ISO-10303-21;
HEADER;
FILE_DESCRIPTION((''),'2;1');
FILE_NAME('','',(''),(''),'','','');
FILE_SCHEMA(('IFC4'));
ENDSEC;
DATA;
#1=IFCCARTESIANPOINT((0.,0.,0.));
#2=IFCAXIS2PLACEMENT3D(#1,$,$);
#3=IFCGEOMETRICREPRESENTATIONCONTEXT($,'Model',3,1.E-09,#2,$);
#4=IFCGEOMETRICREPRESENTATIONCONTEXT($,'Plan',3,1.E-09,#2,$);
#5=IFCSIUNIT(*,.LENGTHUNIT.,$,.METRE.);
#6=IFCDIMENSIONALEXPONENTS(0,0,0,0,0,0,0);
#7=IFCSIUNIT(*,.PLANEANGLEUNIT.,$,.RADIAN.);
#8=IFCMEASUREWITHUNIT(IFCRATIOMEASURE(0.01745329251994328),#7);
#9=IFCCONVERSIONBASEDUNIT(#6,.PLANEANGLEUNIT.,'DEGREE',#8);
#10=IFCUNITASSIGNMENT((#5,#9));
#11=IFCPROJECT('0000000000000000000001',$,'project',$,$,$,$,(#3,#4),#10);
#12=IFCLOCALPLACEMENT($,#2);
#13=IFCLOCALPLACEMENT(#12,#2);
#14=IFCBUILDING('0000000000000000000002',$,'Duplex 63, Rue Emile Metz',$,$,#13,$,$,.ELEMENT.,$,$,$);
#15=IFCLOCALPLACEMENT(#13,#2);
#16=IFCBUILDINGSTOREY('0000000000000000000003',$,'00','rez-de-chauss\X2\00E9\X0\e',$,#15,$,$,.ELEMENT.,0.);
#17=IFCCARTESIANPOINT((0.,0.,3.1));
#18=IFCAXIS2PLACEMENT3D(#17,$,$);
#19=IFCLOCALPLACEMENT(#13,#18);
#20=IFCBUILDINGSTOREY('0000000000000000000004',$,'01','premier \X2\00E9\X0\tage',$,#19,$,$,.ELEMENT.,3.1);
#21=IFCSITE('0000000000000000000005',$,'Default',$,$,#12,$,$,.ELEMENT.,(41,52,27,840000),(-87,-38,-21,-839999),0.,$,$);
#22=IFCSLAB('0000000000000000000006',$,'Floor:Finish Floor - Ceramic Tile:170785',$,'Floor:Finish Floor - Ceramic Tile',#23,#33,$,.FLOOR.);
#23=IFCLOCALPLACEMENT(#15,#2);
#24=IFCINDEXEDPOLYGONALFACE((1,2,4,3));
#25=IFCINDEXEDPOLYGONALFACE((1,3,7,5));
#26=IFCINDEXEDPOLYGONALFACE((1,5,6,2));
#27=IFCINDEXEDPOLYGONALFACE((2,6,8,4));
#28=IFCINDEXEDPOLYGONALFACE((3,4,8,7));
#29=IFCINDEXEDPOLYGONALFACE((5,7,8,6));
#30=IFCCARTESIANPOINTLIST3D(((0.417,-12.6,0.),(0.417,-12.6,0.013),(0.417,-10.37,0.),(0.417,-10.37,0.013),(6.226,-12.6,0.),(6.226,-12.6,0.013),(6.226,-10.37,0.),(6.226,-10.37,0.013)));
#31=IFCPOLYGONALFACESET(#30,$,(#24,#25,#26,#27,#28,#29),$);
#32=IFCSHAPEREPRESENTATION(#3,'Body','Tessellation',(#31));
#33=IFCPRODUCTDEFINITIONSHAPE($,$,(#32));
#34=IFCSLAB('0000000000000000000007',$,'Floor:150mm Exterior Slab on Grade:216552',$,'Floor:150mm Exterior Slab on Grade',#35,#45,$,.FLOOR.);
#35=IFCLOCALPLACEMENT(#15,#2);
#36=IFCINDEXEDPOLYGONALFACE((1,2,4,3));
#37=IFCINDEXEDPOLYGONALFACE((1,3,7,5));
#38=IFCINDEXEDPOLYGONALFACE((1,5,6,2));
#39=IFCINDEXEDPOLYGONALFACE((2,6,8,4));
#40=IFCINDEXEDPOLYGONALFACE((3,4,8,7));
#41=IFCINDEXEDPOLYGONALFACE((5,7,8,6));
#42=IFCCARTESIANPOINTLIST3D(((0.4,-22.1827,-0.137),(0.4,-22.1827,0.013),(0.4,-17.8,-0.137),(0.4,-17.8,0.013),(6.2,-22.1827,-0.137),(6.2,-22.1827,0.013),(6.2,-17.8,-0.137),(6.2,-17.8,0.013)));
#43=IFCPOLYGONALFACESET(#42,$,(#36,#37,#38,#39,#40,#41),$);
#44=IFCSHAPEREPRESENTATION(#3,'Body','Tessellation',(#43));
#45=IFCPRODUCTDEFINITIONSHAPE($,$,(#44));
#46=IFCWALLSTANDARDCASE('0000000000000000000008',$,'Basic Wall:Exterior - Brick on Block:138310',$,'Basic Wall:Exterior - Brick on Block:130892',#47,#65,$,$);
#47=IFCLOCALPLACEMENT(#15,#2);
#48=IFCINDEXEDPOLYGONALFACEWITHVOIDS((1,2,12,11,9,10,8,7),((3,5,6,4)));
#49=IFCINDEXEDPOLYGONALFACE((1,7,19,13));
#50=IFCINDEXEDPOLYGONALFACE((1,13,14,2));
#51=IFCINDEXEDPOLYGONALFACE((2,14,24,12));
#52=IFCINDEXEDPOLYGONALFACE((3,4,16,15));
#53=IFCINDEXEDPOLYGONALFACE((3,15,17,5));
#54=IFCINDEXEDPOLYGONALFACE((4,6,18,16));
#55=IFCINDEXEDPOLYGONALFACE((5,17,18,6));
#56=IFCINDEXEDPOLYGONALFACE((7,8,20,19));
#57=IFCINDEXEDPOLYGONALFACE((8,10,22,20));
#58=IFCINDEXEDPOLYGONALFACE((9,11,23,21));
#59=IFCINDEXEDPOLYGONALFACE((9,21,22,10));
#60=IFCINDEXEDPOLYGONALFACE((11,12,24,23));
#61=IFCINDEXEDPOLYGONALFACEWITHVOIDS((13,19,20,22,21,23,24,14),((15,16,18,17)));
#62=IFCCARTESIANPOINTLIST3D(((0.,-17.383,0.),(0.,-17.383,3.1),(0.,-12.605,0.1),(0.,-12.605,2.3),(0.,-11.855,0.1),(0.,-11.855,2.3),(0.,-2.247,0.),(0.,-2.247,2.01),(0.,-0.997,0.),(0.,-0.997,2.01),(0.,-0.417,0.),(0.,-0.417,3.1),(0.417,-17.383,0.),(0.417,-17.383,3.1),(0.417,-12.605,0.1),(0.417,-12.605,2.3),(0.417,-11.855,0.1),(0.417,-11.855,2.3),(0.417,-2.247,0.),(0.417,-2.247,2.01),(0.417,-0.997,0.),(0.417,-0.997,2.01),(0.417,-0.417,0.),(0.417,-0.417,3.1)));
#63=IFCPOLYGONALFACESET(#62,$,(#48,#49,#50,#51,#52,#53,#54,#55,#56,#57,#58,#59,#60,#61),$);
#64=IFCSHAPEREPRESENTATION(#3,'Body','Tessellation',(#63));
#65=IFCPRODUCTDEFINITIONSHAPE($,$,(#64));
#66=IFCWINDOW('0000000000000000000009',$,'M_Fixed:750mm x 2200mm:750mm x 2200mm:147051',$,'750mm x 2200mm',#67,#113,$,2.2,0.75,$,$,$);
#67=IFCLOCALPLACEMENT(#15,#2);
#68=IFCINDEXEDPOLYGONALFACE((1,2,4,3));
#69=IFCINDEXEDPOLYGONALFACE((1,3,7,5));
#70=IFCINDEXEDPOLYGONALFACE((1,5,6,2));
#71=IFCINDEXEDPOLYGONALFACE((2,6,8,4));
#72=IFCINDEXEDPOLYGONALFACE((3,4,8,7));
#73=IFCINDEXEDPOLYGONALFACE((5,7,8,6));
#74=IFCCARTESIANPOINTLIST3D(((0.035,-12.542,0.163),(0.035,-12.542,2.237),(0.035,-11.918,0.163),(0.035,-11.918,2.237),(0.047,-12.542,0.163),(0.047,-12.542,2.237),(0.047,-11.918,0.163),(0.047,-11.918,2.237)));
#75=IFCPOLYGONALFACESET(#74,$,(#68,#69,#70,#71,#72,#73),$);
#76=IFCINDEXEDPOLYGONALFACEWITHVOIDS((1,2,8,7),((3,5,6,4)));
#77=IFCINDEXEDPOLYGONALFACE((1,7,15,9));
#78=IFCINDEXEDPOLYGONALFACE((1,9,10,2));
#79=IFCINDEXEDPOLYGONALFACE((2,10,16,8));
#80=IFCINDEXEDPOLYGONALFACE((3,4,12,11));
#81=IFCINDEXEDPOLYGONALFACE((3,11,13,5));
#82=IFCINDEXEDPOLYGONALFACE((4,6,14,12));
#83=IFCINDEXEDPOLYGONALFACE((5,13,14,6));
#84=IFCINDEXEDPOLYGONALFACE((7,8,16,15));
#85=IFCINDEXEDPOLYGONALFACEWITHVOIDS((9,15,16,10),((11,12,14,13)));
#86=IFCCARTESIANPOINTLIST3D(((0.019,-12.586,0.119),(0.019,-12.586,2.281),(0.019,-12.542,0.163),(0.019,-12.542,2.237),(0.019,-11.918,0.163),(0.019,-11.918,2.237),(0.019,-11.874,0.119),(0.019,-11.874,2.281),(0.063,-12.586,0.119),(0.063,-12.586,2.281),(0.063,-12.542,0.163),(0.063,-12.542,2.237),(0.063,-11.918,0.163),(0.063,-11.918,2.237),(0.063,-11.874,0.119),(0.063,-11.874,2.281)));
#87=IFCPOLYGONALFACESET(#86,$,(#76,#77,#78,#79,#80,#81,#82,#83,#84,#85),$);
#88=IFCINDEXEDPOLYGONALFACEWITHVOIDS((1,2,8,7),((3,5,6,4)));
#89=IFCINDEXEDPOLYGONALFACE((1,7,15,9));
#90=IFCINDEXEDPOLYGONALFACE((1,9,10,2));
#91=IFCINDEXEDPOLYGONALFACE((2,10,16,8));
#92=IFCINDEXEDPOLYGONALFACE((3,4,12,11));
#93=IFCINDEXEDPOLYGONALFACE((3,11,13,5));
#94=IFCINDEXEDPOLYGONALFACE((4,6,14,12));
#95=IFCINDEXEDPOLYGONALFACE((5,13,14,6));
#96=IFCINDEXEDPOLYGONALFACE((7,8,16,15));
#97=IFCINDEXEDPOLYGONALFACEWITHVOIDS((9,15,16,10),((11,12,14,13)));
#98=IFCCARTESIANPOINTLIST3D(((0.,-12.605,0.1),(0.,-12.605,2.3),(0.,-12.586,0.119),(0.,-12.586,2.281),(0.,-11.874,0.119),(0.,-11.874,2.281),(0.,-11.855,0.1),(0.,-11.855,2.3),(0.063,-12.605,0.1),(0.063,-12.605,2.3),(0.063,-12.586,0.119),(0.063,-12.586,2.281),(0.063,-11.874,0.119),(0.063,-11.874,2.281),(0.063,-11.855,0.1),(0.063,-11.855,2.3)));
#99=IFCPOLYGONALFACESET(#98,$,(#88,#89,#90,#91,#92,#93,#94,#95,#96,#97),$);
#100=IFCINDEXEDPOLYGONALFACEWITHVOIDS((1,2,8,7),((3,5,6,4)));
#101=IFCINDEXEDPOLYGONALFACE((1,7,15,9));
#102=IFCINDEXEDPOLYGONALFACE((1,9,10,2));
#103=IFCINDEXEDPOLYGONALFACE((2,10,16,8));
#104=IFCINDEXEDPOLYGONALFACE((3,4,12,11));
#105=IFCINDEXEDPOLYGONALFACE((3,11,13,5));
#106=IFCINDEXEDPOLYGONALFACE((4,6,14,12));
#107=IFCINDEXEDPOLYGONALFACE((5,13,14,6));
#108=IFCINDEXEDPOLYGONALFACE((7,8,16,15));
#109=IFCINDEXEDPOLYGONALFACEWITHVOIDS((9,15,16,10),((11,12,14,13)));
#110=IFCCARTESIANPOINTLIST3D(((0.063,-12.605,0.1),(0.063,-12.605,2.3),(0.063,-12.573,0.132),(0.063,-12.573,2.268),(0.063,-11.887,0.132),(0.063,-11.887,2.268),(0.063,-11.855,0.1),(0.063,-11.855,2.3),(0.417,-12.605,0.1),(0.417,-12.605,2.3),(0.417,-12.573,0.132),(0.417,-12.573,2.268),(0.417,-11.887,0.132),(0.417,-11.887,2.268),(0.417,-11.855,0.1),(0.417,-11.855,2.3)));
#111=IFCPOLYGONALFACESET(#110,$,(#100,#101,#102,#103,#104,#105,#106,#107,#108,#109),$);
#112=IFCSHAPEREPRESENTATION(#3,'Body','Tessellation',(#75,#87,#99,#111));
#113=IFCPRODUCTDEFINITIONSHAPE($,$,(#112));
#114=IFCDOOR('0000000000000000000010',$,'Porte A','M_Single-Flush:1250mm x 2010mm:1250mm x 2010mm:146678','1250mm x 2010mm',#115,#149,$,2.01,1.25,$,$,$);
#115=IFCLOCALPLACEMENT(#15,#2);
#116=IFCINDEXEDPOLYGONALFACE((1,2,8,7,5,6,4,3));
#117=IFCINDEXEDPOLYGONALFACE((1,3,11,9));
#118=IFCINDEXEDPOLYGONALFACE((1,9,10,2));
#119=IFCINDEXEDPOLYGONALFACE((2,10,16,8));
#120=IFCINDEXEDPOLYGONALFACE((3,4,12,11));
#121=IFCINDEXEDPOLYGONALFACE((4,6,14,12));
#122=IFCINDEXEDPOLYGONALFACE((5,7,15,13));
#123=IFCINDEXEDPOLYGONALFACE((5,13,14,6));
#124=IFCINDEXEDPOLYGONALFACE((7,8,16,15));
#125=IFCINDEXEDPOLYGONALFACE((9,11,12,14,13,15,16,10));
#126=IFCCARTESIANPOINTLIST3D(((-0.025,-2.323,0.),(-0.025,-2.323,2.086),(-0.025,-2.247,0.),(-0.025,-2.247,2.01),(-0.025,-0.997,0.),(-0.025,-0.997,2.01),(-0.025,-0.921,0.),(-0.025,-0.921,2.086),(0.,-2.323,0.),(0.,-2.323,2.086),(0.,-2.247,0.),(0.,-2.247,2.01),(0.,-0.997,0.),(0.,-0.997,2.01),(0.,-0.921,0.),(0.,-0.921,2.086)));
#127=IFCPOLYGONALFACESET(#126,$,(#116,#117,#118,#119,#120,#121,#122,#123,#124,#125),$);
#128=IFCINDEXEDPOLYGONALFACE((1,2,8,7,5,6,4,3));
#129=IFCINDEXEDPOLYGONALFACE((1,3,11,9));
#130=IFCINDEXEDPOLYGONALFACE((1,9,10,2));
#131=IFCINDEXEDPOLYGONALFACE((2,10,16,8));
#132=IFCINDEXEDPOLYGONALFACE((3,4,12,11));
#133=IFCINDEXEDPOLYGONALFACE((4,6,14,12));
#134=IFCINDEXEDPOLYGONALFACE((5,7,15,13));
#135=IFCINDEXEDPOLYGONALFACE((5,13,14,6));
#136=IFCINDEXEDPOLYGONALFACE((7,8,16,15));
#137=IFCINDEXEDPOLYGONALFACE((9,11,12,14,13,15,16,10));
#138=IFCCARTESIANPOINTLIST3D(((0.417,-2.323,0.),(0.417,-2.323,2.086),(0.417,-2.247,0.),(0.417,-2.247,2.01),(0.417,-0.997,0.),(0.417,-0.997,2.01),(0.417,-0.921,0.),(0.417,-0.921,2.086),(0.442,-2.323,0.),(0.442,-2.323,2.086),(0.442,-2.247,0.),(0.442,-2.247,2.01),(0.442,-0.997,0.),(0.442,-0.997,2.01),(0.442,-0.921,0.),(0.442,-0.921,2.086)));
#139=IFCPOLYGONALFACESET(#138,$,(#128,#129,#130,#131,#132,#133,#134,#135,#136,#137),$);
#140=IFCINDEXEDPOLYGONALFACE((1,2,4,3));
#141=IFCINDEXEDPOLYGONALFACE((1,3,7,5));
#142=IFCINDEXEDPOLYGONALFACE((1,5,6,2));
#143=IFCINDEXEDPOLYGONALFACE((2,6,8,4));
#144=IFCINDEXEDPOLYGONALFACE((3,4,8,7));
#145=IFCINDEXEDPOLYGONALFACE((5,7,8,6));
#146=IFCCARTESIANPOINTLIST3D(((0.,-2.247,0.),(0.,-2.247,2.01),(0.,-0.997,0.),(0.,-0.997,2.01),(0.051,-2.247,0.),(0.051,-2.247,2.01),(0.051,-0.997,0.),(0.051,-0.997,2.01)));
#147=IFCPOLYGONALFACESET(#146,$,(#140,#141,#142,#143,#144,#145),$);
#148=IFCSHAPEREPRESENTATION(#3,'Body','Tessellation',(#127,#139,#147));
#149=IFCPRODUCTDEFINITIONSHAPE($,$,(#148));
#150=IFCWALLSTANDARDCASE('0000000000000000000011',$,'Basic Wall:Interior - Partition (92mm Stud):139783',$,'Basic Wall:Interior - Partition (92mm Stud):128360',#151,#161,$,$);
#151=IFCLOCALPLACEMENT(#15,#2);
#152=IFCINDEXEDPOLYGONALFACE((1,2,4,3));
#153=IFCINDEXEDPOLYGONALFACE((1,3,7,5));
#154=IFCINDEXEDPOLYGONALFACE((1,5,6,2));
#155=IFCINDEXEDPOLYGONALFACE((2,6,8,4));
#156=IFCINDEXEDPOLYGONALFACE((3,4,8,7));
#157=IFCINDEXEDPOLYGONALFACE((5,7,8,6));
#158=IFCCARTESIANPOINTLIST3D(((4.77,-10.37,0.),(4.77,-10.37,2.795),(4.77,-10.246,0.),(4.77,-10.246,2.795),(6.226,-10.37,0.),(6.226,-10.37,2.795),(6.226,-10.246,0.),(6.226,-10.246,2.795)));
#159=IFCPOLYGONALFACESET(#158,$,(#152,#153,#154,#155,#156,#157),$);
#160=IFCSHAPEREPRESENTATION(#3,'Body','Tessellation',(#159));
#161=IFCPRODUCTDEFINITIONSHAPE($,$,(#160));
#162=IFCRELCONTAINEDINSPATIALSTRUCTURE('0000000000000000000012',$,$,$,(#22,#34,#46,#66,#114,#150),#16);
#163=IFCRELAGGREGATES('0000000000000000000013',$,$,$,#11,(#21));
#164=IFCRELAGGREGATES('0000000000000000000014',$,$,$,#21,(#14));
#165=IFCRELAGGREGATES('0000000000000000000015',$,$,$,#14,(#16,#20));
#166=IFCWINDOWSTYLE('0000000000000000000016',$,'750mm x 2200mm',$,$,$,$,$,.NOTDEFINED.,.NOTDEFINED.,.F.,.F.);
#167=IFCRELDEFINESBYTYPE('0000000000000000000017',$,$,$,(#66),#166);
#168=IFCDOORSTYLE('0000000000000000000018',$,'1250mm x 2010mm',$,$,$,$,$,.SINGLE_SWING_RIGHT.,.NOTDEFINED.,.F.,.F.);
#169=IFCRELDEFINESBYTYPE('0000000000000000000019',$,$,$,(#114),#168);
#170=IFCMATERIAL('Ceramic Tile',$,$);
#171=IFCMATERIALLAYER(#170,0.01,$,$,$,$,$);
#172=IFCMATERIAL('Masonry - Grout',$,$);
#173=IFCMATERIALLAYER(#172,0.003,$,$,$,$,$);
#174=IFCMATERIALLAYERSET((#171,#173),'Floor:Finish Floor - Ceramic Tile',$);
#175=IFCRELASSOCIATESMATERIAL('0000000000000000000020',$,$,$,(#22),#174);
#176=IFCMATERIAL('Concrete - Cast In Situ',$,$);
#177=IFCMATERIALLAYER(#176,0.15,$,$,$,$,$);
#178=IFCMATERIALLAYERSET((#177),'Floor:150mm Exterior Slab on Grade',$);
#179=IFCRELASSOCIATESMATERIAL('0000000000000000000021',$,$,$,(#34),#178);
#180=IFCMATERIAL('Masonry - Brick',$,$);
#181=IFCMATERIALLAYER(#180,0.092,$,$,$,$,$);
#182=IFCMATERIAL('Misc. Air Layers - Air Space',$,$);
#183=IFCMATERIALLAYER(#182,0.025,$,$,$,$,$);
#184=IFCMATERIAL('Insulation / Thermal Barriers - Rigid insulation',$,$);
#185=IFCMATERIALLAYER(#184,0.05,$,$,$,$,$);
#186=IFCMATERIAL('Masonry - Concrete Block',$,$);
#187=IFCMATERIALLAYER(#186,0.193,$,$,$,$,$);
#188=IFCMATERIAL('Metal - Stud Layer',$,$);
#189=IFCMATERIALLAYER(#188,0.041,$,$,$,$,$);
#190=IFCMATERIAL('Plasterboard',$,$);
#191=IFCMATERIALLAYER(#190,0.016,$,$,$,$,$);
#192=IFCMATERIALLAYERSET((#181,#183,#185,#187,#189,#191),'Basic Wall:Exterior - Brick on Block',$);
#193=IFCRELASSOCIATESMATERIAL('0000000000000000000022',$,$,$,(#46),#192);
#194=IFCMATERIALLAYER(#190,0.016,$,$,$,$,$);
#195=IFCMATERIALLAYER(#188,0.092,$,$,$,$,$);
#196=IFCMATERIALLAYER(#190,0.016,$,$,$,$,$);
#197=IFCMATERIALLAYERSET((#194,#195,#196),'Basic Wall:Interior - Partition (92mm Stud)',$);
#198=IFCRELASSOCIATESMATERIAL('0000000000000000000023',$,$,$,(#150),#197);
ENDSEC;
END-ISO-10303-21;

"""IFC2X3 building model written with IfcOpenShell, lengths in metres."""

from ifc_helpers import new_model, entity, si_unit, converted_unit, frame, frame_2d, origin, origin_2d_with_axis, place, context, project, spatial, polyline, rectangle, outline, extrude, source, transform, mapped, material, layer, layer_set, layer_usage, type_object, type_shapes, element, fill, save


model = new_model("IFC2X3")

# Units and contexts
model_context = context("Model", 3, precision=1e-09, world=origin())
plan_context = context("Plan", 3, precision=1e-09, world=origin())
ifc_project = project(units=[si_unit("LENGTHUNIT", "METRE"), converted_unit("PLANEANGLEUNIT", "DEGREE", entity("IfcRatioMeasure", 0.01745329251994328), si_unit("PLANEANGLEUNIT", "RADIAN"), dimensions=[0, 0, 0, 0, 0, 0, 0])], contexts=[model_context, plan_context])

# Site, building, storey
site_placement = place(None, origin())
site = spatial("IfcSite", under=ifc_project, at=site_placement, Name="Default", CompositionType="ELEMENT", RefLatitude=(41, 52, 27, 840000), RefLongitude=(-87, -38, -21, -839999), RefElevation=0.0)
building_placement = place(site_placement, origin())
building = spatial("IfcBuilding", under=site, at=building_placement, Name="Duplex 63, Rue Emile Metz", CompositionType="ELEMENT")
storey_1_placement = place(building_placement, origin())
storey_1 = spatial("IfcBuildingStorey", under=building, at=storey_1_placement, Name="00", Description="rez-de-chaussée", CompositionType="ELEMENT", Elevation=0.0)

# Slabs
ifc_material_1 = material(Name="Ceramic Tile")
ifc_layer_1 = layer(ifc_material_1, 0.01)
ifc_material_2 = material(Name="Masonry - Grout")
ifc_layer_2 = layer(ifc_material_2, 0.003)
ifc_layer_set_1 = layer_set([ifc_layer_1, ifc_layer_2], Name="Floor:Finish Floor - Ceramic Tile")
ifc_layer_usage_1 = layer_usage(ifc_layer_set_1, "AXIS3", "POSITIVE", 0.0)
slab_1_placement = place(storey_1_placement, frame((0.417, -12.6, 0.0)))
element("IfcSlab", 1, at=slab_1_placement, inside=storey_1, material=ifc_layer_usage_1, Name="Floor:Finish Floor - Ceramic Tile:170785", ObjectType="Floor:Finish Floor - Ceramic Tile", PredefinedType="FLOOR", context=model_context, shape_type="SweptSolid", body=[
    extrude(rectangle(XDim=5.809, YDim=2.23, at=frame_2d((0.0, 0.0), x_axis=(-1.0, 0.0))), frame((2.9045, 1.115, 0.013), z_axis=(0.0, 0.0, -1.0), x_axis=(-1.0, 0.0, 0.0)), (0.0, 0.0, 1.0), 0.013),
])
ifc_material_3 = material(Name="Concrete - Cast In Situ")
ifc_layer_3 = layer(ifc_material_3, 0.15)
ifc_layer_set_2 = layer_set([ifc_layer_3], Name="Floor:150mm Exterior Slab on Grade")
ifc_layer_usage_2 = layer_usage(ifc_layer_set_2, "AXIS3", "POSITIVE", 0.0)
slab_2_placement = place(storey_1_placement, frame((0.4, -22.1827, -0.137)))
element("IfcSlab", 2, at=slab_2_placement, inside=storey_1, material=ifc_layer_usage_2, Name="Floor:150mm Exterior Slab on Grade:216552", ObjectType="Floor:150mm Exterior Slab on Grade", PredefinedType="FLOOR", context=model_context, shape_type="SweptSolid", body=[
    extrude(rectangle(XDim=5.8, YDim=4.3827, at=origin_2d_with_axis()), frame((2.9, 2.1914, 0.15), z_axis=(0.0, 0.0, -1.0), x_axis=(-1.0, 0.0, 0.0)), (0.0, 0.0, 1.0), 0.15),
])

# Wall, openings, window, door
ifc_material_4 = material(Name="Masonry - Brick")
ifc_layer_4 = layer(ifc_material_4, 0.092)
ifc_material_5 = material(Name="Misc. Air Layers - Air Space")
ifc_layer_5 = layer(ifc_material_5, 0.025)
ifc_material_6 = material(Name="Insulation / Thermal Barriers - Rigid insulation")
ifc_layer_6 = layer(ifc_material_6, 0.05)
ifc_material_7 = material(Name="Masonry - Concrete Block")
ifc_layer_7 = layer(ifc_material_7, 0.193)
ifc_material_8 = material(Name="Metal - Stud Layer")
ifc_layer_8 = layer(ifc_material_8, 0.041)
ifc_material_9 = material(Name="Plasterboard")
ifc_layer_9 = layer(ifc_material_9, 0.016)
ifc_layer_set_3 = layer_set([ifc_layer_4, ifc_layer_5, ifc_layer_6, ifc_layer_7, ifc_layer_8, ifc_layer_9], Name="Basic Wall:Exterior - Brick on Block")
ifc_layer_usage_3 = layer_usage(ifc_layer_set_3, "AXIS2", "NEGATIVE", 0.2085)
wall_1_placement = place(storey_1_placement, frame((0.2085, -17.383, 0.0), z_axis=(0.0, 0.0, 1.0), x_axis=(0.0, 1.0, 0.0)))
wall_1 = element("IfcWallStandardCase", 3, at=wall_1_placement, inside=storey_1, material=ifc_layer_usage_3, Name="Basic Wall:Exterior - Brick on Block:138310", ObjectType="Basic Wall:Exterior - Brick on Block:130892", context=model_context, shape_type="SweptSolid", body=[
    extrude(rectangle(XDim=16.966, YDim=0.417, at=frame_2d((8.483, 0.0), x_axis=(-1.0, 0.0))), origin(), (0.0, 0.0, 1.0), 3.1),
])
opening_1_placement = place(wall_1_placement, frame((15.136, -0.2085, 0.0)))
opening_1 = element("IfcOpeningElement", 4, at=opening_1_placement, cuts=wall_1, ObjectType="Opening", context=model_context, shape_type="SweptSolid", body=[
    extrude(rectangle(XDim=1.25, YDim=2.01, at=frame_2d((1.005, 0.625), x_axis=(0.0, 1.0))), frame((0.0, 0.0, 0.0), z_axis=(0.0, 1.0, 0.0), x_axis=(0.0, 0.0, 1.0)), (0.0, 0.0, 1.0), 0.417),
])
opening_2_placement = place(wall_1_placement, frame((4.778, -0.2085, 0.1)))
opening_2 = element("IfcOpeningElement", 5, at=opening_2_placement, cuts=wall_1, ObjectType="Opening", context=model_context, shape_type="SweptSolid", body=[
    extrude(rectangle(XDim=2.2, YDim=0.75, at=frame_2d((1.1, 0.375), x_axis=(1.0, 0.0))), frame((0.0, 0.0, 0.0), z_axis=(0.0, 1.0, 0.0), x_axis=(0.0, 0.0, 1.0)), (0.0, 0.0, 1.0), 0.417),
])
window_style_1 = type_object("IfcWindowStyle", Name="750mm x 2200mm", ConstructionType="NOTDEFINED", OperationType="NOTDEFINED", ParameterTakesPrecedence=False, Sizeable=False)
shared_shape_1 = source(origin(), model_context, "Body", "SweptSolid", [
    extrude(rectangle(XDim=0.012, YDim=0.624, at=origin_2d_with_axis()), frame((0.375, 0.376, 0.063), z_axis=(0.0, 0.0, 1.0), x_axis=(0.0, -1.0, 0.0)), (0.0, 0.0, 1.0), 2.074),
    extrude(outline(polyline([(-0.356, -1.081), (0.356, -1.081), (0.356, 1.081), (-0.356, 1.081), (-0.356, -1.081)]), holes=[polyline([(-0.312, -1.037), (-0.312, 1.037), (0.312, 1.037), (0.312, -1.037), (-0.312, -1.037)])]), frame((0.375, 0.354, 1.1), z_axis=(0.0, 1.0, 0.0), x_axis=(1.0, 0.0, 0.0)), (0.0, 0.0, 1.0), 0.044),
    extrude(outline(polyline([(-0.375, -1.1), (0.375, -1.1), (0.375, 1.1), (-0.375, 1.1), (-0.375, -1.1)]), holes=[polyline([(-0.356, -1.081), (-0.356, 1.081), (0.356, 1.081), (0.356, -1.081), (-0.356, -1.081)])]), frame((0.375, 0.354, 1.1), z_axis=(0.0, 1.0, 0.0), x_axis=(1.0, 0.0, 0.0)), (0.0, 0.0, 1.0), 0.063),
    extrude(outline(polyline([(-0.375, -1.1), (0.375, -1.1), (0.375, 1.1), (-0.375, 1.1), (-0.375, -1.1)]), holes=[polyline([(-0.343, -1.068), (-0.343, 1.068), (0.343, 1.068), (0.343, -1.068), (-0.343, -1.068)])]), frame((0.375, 0.0, 1.1), z_axis=(0.0, 1.0, 0.0), x_axis=(1.0, 0.0, 0.0)), (0.0, 0.0, 1.0), 0.354),
])
type_shapes(window_style_1, [shared_shape_1])
window_1_placement = place(opening_2_placement, origin())
window_1 = element("IfcWindow", 6, at=window_1_placement, inside=storey_1, type_object=window_style_1, Name="M_Fixed:750mm x 2200mm:750mm x 2200mm:147051", ObjectType="750mm x 2200mm", OverallHeight=2.2, OverallWidth=0.75, context=model_context, shape_type="MappedRepresentation", body=[
    mapped(shared_shape_1, transform((0.0, 0.0, 0.0), scale=1.0)),
])
fill(opening_2, window_1)
door_style_1 = type_object("IfcDoorStyle", Name="1250mm x 2010mm", ConstructionType="NOTDEFINED", OperationType="SINGLE_SWING_RIGHT", ParameterTakesPrecedence=False, Sizeable=False)
shared_shape_2 = source(origin(), model_context, "Body", "SweptSolid", [
    extrude(outline(polyline([(-0.701, -1.062), (0.701, -1.062), (0.701, 1.024), (0.625, 1.024), (0.625, -0.986), (-0.625, -0.986), (-0.625, 1.024), (-0.701, 1.024), (-0.701, -1.062)])), frame((0.625, 0.417, 1.024), z_axis=(0.0, 1.0, 0.0), x_axis=(1.0, 0.0, 0.0)), (0.0, 0.0, 1.0), 0.025),
    extrude(outline(polyline([(-1.062, -0.701), (1.024, -0.701), (1.024, -0.625), (-0.986, -0.625), (-0.986, 0.625), (1.024, 0.625), (1.024, 0.701), (-1.062, 0.701), (-1.062, -0.701)])), frame((0.625, -0.025, 1.024), z_axis=(0.0, 1.0, 0.0), x_axis=(0.0, 0.0, -1.0)), (0.0, 0.0, 1.0), 0.025),
    extrude(rectangle(XDim=0.051, YDim=1.25, at=origin_2d_with_axis()), frame((0.625, 0.3915, 0.0), z_axis=(0.0, 0.0, 1.0), x_axis=(0.0, 1.0, 0.0)), (0.0, 0.0, 1.0), 2.01),
])
type_shapes(door_style_1, [shared_shape_2])
door_1_placement = place(opening_1_placement, origin())
door_1 = element("IfcDoor", 7, at=door_1_placement, inside=storey_1, type_object=door_style_1, Name="Porte A", Description="M_Single-Flush:1250mm x 2010mm:1250mm x 2010mm:146678", ObjectType="1250mm x 2010mm", OverallHeight=2.01, OverallWidth=1.25, context=model_context, shape_type="MappedRepresentation", body=[
    mapped(shared_shape_2, transform((0.0, 0.0, 0.0), scale=1.0)),
])
fill(opening_1, door_1)

# Wall
ifc_layer_10 = layer(ifc_material_9, 0.016)
ifc_layer_11 = layer(ifc_material_8, 0.092)
ifc_layer_12 = layer(ifc_material_9, 0.016)
ifc_layer_set_4 = layer_set([ifc_layer_10, ifc_layer_11, ifc_layer_12], Name="Basic Wall:Interior - Partition (92mm Stud)")
ifc_layer_usage_4 = layer_usage(ifc_layer_set_4, "AXIS2", "NEGATIVE", 0.062)
wall_2_placement = place(storey_1_placement, frame((4.77, -10.308, 0.0)))
element("IfcWallStandardCase", 8, at=wall_2_placement, inside=storey_1, material=ifc_layer_usage_4, Name="Basic Wall:Interior - Partition (92mm Stud):139783", ObjectType="Basic Wall:Interior - Partition (92mm Stud):128360", context=model_context, shape_type="SweptSolid", body=[
    extrude(rectangle(XDim=1.456, YDim=0.124, at=frame_2d((0.728, 0.0), x_axis=(-1.0, 0.0))), origin(), (0.0, 0.0, 1.0), 2.795),
])

# Shared definitions
storey_2_placement = place(building_placement, frame((0.0, 0.0, 3.1)))
storey_2 = spatial("IfcBuildingStorey", under=building, at=storey_2_placement, Name="01", Description="premier étage", CompositionType="ELEMENT", Elevation=3.1)

save(model, "model.ifc")
